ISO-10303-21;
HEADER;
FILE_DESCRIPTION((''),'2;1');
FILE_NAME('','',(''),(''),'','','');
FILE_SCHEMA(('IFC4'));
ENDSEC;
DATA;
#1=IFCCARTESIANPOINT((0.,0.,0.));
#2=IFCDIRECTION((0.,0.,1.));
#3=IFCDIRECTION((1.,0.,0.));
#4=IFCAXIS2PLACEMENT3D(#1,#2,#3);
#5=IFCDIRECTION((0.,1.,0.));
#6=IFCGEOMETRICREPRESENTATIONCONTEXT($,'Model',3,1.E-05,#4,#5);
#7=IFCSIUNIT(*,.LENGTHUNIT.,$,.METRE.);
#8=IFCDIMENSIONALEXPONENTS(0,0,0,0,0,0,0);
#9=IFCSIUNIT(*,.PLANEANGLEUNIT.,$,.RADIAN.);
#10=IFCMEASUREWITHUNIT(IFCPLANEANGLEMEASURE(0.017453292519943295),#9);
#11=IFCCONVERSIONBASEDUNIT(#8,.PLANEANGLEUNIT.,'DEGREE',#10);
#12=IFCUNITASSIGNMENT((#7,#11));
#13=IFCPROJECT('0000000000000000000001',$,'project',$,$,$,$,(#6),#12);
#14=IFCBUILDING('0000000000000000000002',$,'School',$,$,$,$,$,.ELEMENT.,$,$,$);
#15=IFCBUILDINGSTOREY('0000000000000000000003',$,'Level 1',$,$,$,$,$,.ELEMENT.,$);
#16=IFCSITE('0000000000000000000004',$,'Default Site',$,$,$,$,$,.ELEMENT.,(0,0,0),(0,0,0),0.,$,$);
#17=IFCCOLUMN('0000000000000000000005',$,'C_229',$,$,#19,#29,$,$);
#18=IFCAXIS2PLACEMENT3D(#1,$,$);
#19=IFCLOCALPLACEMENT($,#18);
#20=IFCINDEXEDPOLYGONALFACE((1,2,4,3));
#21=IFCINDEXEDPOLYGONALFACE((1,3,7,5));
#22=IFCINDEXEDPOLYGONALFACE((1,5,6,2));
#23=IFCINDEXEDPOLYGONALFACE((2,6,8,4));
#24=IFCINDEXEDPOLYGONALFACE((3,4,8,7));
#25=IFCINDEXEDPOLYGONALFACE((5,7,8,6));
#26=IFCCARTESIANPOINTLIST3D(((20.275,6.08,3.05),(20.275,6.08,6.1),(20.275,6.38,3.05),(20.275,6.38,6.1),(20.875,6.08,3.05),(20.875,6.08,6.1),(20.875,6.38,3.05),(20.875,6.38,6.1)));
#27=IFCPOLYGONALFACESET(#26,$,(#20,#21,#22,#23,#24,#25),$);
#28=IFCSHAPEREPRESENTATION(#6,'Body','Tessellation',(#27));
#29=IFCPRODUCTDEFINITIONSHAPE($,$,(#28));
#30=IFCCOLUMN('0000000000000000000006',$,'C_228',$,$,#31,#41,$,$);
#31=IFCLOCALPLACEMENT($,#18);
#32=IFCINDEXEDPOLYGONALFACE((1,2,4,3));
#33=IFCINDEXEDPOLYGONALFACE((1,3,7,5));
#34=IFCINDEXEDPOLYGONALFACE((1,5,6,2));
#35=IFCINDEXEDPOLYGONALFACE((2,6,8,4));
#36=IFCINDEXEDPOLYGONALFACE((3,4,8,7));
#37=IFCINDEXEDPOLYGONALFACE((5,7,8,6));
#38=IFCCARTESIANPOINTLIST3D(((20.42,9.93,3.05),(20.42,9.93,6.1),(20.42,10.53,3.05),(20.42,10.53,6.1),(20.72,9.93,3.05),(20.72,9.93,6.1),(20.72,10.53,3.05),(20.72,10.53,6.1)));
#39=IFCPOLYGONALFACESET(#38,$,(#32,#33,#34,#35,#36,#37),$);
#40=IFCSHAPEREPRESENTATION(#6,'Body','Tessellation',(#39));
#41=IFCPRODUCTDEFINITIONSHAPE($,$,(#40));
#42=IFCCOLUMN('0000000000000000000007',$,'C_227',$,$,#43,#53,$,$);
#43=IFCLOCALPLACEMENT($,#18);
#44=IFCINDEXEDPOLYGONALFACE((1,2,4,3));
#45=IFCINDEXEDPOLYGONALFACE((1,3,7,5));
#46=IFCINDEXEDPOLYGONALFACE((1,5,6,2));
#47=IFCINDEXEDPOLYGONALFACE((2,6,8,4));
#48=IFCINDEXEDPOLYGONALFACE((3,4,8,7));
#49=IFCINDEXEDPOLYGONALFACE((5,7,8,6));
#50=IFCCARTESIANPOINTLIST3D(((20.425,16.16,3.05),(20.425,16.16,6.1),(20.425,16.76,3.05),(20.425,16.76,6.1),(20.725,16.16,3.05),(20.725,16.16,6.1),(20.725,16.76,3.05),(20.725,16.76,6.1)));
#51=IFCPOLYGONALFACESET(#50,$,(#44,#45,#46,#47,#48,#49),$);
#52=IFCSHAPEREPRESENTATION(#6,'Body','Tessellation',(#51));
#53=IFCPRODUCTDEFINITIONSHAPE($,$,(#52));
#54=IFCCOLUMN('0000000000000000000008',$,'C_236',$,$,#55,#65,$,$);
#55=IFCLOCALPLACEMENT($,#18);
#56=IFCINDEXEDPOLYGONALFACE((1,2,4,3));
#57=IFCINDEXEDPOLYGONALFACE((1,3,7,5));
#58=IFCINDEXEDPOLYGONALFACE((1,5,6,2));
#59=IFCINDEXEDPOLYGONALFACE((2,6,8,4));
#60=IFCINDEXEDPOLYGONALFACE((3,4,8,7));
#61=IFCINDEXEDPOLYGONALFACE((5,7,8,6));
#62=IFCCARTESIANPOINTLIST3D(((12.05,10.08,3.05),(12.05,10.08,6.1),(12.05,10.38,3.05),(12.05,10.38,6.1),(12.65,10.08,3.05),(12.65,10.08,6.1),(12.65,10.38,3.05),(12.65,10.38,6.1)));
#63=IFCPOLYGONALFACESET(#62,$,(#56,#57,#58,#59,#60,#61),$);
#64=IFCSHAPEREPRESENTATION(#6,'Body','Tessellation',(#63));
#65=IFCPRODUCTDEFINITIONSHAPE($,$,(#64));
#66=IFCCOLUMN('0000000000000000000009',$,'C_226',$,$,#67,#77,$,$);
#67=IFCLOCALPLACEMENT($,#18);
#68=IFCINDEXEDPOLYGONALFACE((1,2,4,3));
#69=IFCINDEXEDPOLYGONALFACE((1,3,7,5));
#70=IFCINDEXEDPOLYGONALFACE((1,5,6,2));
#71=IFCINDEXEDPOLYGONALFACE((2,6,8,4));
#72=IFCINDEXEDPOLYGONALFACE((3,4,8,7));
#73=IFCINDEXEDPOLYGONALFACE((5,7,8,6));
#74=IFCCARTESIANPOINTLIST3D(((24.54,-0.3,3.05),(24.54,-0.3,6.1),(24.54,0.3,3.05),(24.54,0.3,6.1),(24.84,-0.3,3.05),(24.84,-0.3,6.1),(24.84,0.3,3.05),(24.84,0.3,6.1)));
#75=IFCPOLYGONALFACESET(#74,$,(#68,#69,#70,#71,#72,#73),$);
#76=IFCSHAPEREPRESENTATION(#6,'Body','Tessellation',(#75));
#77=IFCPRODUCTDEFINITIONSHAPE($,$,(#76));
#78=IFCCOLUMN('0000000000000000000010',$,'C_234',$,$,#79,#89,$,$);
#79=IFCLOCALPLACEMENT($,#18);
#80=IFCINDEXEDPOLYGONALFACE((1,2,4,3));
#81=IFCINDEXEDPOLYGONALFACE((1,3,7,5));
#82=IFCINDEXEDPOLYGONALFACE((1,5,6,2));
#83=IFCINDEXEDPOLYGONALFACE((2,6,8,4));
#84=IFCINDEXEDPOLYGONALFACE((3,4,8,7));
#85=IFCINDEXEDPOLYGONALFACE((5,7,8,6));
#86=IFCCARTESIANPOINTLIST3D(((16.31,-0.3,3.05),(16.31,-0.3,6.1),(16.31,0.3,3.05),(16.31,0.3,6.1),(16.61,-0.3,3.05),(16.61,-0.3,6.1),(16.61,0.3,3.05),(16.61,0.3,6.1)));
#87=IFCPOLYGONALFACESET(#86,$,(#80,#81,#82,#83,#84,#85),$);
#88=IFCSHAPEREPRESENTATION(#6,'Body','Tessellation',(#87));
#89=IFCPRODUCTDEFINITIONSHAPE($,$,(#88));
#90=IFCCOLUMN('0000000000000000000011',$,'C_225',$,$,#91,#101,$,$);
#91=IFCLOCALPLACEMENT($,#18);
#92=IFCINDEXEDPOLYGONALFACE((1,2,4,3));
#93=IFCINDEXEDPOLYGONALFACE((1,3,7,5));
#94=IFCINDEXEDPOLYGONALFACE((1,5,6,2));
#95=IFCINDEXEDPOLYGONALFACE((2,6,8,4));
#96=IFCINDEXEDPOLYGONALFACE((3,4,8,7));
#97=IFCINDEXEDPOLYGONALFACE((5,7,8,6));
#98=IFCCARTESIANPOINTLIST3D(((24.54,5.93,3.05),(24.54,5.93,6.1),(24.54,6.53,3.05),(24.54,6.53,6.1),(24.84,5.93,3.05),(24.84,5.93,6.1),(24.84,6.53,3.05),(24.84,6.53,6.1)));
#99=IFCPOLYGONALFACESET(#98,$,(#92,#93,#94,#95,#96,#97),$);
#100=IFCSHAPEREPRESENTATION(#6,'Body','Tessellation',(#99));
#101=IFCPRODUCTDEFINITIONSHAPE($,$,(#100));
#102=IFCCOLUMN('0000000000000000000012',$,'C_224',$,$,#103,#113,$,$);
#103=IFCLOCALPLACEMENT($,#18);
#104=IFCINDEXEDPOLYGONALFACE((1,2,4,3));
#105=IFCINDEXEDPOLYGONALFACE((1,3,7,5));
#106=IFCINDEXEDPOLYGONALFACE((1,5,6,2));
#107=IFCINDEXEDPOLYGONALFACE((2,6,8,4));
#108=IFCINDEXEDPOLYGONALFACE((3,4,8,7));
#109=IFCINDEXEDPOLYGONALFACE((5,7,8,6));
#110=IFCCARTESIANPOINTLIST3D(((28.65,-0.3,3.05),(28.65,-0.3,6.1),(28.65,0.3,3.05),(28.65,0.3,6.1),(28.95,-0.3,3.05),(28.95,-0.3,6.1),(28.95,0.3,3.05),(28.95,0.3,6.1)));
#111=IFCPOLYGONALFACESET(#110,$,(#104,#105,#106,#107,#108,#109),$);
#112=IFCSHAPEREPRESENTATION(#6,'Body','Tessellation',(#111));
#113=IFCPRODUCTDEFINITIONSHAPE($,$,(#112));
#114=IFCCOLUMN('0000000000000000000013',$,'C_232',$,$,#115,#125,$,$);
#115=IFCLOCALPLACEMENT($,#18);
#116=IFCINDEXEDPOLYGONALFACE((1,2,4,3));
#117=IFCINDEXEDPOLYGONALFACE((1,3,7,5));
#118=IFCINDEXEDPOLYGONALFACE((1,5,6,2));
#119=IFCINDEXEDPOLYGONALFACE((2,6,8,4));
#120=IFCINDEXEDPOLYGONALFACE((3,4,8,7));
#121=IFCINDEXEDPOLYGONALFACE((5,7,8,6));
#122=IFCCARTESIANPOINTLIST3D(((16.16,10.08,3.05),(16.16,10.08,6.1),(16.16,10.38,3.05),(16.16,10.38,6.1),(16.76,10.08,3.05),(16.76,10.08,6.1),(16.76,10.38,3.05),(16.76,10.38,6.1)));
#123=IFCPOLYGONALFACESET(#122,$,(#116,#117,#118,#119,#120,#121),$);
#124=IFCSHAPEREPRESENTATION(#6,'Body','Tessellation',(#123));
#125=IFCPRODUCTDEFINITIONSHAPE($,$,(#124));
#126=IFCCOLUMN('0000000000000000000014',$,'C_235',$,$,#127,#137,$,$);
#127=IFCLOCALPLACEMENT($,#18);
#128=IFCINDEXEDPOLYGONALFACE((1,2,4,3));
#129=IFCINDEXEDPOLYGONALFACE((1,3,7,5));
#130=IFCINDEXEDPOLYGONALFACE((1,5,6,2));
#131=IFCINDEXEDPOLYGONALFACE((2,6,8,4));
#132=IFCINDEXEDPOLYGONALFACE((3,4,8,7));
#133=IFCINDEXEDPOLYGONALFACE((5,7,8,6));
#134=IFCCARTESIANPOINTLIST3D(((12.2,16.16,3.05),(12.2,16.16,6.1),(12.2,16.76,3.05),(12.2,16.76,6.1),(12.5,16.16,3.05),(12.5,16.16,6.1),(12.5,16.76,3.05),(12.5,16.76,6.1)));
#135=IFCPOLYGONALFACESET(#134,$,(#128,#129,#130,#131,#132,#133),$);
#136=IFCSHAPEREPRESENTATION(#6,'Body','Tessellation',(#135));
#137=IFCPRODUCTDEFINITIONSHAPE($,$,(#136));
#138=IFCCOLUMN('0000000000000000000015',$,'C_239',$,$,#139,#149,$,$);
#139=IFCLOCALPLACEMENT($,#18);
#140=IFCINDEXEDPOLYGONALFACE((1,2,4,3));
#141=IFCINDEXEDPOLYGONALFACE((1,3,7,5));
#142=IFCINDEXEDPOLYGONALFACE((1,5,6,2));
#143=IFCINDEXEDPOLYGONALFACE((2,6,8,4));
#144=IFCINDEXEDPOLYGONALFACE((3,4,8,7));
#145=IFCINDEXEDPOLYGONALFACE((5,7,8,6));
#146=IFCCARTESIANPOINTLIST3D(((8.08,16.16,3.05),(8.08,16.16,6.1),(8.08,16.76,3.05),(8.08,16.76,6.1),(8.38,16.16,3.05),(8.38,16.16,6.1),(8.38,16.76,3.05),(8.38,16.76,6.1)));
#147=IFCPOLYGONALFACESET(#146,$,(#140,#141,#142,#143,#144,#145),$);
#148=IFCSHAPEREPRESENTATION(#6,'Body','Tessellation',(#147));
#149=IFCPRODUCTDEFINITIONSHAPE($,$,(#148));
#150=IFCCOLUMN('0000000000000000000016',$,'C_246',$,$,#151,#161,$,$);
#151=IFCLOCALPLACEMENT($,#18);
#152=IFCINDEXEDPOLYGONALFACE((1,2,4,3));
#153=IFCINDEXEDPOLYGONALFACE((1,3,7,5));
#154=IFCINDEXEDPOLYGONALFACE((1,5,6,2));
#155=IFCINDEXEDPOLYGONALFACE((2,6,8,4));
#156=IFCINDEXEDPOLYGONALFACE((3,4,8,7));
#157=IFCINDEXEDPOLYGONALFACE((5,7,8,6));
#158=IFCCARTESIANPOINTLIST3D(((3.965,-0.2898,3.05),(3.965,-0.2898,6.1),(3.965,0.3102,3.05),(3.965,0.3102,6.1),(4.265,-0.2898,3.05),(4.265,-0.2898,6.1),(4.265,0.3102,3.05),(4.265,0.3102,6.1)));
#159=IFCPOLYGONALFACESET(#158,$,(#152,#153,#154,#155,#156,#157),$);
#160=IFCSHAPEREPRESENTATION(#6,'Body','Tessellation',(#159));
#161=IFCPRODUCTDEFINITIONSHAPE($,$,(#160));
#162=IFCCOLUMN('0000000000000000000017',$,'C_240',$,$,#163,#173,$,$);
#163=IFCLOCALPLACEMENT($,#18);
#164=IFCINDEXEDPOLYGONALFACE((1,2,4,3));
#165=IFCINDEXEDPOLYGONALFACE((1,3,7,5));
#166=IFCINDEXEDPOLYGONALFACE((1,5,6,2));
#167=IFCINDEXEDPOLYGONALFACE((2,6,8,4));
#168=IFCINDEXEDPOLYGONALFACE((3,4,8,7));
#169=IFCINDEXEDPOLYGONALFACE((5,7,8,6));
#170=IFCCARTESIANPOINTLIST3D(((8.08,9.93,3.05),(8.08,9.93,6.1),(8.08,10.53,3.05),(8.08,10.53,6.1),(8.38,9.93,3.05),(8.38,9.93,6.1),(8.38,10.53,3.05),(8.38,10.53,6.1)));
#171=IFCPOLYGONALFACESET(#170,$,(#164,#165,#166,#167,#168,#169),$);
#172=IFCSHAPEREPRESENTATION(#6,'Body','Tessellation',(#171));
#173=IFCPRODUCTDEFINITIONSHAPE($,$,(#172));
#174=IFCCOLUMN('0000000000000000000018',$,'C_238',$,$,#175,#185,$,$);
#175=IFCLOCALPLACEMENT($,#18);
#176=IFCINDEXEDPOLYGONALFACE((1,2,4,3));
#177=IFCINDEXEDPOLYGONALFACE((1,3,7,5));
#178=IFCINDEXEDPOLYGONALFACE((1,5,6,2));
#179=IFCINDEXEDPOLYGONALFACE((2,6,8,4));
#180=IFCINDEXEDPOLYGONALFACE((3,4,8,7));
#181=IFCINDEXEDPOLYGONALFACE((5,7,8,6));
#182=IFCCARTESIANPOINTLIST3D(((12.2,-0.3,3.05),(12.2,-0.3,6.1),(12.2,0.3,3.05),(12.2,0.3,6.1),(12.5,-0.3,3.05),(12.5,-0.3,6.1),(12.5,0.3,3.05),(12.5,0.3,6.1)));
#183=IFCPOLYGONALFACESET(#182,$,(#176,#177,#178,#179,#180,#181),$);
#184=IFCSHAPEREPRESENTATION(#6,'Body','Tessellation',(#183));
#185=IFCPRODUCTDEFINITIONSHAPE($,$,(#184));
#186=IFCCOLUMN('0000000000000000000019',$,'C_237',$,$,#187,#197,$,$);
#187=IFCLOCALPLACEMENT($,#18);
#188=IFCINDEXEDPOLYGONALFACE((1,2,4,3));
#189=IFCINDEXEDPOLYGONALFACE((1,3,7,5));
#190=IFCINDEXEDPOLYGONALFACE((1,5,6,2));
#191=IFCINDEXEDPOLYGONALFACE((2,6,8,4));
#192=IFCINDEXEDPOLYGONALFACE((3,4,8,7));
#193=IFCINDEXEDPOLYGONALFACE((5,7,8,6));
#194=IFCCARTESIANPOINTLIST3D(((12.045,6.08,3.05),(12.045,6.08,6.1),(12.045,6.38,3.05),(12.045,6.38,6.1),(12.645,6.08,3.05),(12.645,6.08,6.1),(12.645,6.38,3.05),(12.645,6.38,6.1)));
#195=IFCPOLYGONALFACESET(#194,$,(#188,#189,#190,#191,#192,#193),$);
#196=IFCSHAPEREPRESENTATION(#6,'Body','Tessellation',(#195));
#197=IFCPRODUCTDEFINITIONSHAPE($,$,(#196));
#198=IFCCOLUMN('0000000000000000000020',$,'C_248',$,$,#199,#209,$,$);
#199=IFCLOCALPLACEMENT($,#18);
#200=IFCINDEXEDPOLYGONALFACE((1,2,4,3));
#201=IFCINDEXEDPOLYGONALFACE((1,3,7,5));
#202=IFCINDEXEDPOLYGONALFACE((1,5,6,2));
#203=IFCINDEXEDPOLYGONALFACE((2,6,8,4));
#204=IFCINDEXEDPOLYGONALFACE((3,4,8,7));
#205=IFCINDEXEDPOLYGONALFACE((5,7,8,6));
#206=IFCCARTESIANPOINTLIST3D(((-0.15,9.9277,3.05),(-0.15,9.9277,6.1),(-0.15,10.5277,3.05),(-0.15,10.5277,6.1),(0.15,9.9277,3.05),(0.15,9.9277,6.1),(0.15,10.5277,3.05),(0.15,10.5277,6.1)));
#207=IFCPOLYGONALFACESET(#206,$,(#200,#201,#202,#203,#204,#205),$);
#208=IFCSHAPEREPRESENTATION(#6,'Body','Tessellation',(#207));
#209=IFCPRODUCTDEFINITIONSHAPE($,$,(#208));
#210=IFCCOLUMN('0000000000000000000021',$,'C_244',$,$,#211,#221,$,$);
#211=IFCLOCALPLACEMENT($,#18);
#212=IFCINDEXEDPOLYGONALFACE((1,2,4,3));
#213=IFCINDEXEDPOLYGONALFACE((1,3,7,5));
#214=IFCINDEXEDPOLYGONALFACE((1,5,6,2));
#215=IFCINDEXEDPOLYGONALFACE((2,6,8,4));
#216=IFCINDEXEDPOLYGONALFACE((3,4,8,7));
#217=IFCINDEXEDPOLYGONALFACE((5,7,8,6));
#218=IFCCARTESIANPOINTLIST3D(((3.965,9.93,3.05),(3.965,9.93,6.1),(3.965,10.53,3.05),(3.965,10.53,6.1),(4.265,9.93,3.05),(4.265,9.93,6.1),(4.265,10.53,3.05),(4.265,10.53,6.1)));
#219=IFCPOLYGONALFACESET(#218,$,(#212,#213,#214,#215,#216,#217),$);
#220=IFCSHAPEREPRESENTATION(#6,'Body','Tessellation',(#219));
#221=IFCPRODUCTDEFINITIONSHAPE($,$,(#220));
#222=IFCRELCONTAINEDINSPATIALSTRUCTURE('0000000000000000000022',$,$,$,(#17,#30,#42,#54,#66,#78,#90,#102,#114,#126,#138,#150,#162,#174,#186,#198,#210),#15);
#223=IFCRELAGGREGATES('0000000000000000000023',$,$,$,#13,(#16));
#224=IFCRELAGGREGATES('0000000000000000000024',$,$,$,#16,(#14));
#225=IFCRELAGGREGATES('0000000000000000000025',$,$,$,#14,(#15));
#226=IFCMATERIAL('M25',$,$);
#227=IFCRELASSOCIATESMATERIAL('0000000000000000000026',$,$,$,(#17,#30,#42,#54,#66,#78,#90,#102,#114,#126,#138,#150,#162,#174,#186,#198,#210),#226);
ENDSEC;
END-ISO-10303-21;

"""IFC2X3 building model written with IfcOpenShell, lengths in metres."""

from ifc_helpers import new_model, entity, si_unit, converted_unit, direction, frame, frame_2d, origin_with_axes, place, context, project, spatial, rectangle, extrude, material, element, save


model = new_model("IFC2X3")

# Units and contexts
model_context = context("Model", 3, precision=1e-05, world=origin_with_axes(), true_north=direction((0.0, 1.0, 0.0)))
ifc_project = project(units=[si_unit("LENGTHUNIT", "METRE"), converted_unit("PLANEANGLEUNIT", "DEGREE", entity("IfcPlaneAngleMeasure", 0.017453292519943295), si_unit("PLANEANGLEUNIT", "RADIAN"), dimensions=[0, 0, 0, 0, 0, 0, 0])], contexts=[model_context])

# Site, building, storey
site = spatial("IfcSite", under=ifc_project, Name="Default Site", CompositionType="ELEMENT", RefLatitude=(0, 0, 0), RefLongitude=(0, 0, 0), RefElevation=0.0)
building = spatial("IfcBuilding", under=site, Name="School", CompositionType="ELEMENT")
storey = spatial("IfcBuildingStorey", under=building, Name="Level 1", CompositionType="ELEMENT")

# Columns
ifc_material = material(Name="M25")
placement = place(None, origin_with_axes())
element("IfcColumn", 1, at=placement, inside=storey, material=ifc_material, Name="C_229", context=model_context, shape_type="SweptSolid", body=[
    extrude(rectangle(XDim=0.6, YDim=0.3, at=frame_2d((0.0, 0.0), x_axis=(1.0, 0.0, 0.0))), frame((20.575, 6.23, 3.05), z_axis=(0.0, 0.0, 1.0), x_axis=(1.0, 0.0, 0.0)), (0.0, 0.0, 1.0), 3.05),
])
element("IfcColumn", 2, at=placement, inside=storey, material=ifc_material, Name="C_228", context=model_context, shape_type="SweptSolid", body=[
    extrude(rectangle(XDim=0.3, YDim=0.6, at=frame_2d((0.0, 0.0), x_axis=(1.0, 0.0, 0.0))), frame((20.57, 10.23, 3.05), z_axis=(0.0, 0.0, 1.0), x_axis=(1.0, 0.0, 0.0)), (0.0, 0.0, 1.0), 3.05),
])
element("IfcColumn", 3, at=placement, inside=storey, material=ifc_material, Name="C_227", context=model_context, shape_type="SweptSolid", body=[
    extrude(rectangle(XDim=0.3, YDim=0.6, at=frame_2d((0.0, 0.0), x_axis=(1.0, 0.0, 0.0))), frame((20.575, 16.46, 3.05), z_axis=(0.0, 0.0, 1.0), x_axis=(1.0, 0.0, 0.0)), (0.0, 0.0, 1.0), 3.05),
])
element("IfcColumn", 4, at=placement, inside=storey, material=ifc_material, Name="C_236", context=model_context, shape_type="SweptSolid", body=[
    extrude(rectangle(XDim=0.6, YDim=0.3, at=frame_2d((0.0, 0.0), x_axis=(1.0, 0.0, 0.0))), frame((12.35, 10.23, 3.05), z_axis=(0.0, 0.0, 1.0), x_axis=(1.0, 0.0, 0.0)), (0.0, 0.0, 1.0), 3.05),
])
element("IfcColumn", 5, at=placement, inside=storey, material=ifc_material, Name="C_226", context=model_context, shape_type="SweptSolid", body=[
    extrude(rectangle(XDim=0.3, YDim=0.6, at=frame_2d((0.0, 0.0), x_axis=(1.0, 0.0, 0.0))), frame((24.69, 0.0, 3.05), z_axis=(0.0, 0.0, 1.0), x_axis=(1.0, 0.0, 0.0)), (0.0, 0.0, 1.0), 3.05),
])
element("IfcColumn", 6, at=placement, inside=storey, material=ifc_material, Name="C_234", context=model_context, shape_type="SweptSolid", body=[
    extrude(rectangle(XDim=0.3, YDim=0.6, at=frame_2d((0.0, 0.0), x_axis=(1.0, 0.0, 0.0))), frame((16.46, 0.0, 3.05), z_axis=(0.0, 0.0, 1.0), x_axis=(1.0, 0.0, 0.0)), (0.0, 0.0, 1.0), 3.05),
])
element("IfcColumn", 7, at=placement, inside=storey, material=ifc_material, Name="C_225", context=model_context, shape_type="SweptSolid", body=[
    extrude(rectangle(XDim=0.3, YDim=0.6, at=frame_2d((0.0, 0.0), x_axis=(1.0, 0.0, 0.0))), frame((24.69, 6.23, 3.05), z_axis=(0.0, 0.0, 1.0), x_axis=(1.0, 0.0, 0.0)), (0.0, 0.0, 1.0), 3.05),
])
element("IfcColumn", 8, at=placement, inside=storey, material=ifc_material, Name="C_224", context=model_context, shape_type="SweptSolid", body=[
    extrude(rectangle(XDim=0.3, YDim=0.6, at=frame_2d((0.0, 0.0), x_axis=(1.0, 0.0, 0.0))), frame((28.8, 0.0, 3.05), z_axis=(0.0, 0.0, 1.0), x_axis=(1.0, 0.0, 0.0)), (0.0, 0.0, 1.0), 3.05),
])
element("IfcColumn", 9, at=placement, inside=storey, material=ifc_material, Name="C_232", context=model_context, shape_type="SweptSolid", body=[
    extrude(rectangle(XDim=0.6, YDim=0.3, at=frame_2d((0.0, 0.0), x_axis=(1.0, 0.0, 0.0))), frame((16.46, 10.23, 3.05), z_axis=(0.0, 0.0, 1.0), x_axis=(1.0, 0.0, 0.0)), (0.0, 0.0, 1.0), 3.05),
])
element("IfcColumn", 10, at=placement, inside=storey, material=ifc_material, Name="C_235", context=model_context, shape_type="SweptSolid", body=[
    extrude(rectangle(XDim=0.3, YDim=0.6, at=frame_2d((0.0, 0.0), x_axis=(1.0, 0.0, 0.0))), frame((12.35, 16.46, 3.05), z_axis=(0.0, 0.0, 1.0), x_axis=(1.0, 0.0, 0.0)), (0.0, 0.0, 1.0), 3.05),
])
element("IfcColumn", 11, at=placement, inside=storey, material=ifc_material, Name="C_239", context=model_context, shape_type="SweptSolid", body=[
    extrude(rectangle(XDim=0.3, YDim=0.6, at=frame_2d((0.0, 0.0), x_axis=(1.0, 0.0, 0.0))), frame((8.23, 16.46, 3.05), z_axis=(0.0, 0.0, 1.0), x_axis=(1.0, 0.0, 0.0)), (0.0, 0.0, 1.0), 3.05),
])
element("IfcColumn", 12, at=placement, inside=storey, material=ifc_material, Name="C_246", context=model_context, shape_type="SweptSolid", body=[
    extrude(rectangle(XDim=0.3, YDim=0.6, at=frame_2d((0.0, 0.0), x_axis=(1.0, 0.0, 0.0))), frame((4.115, 0.0102, 3.05), z_axis=(0.0, 0.0, 1.0), x_axis=(1.0, 0.0, 0.0)), (0.0, 0.0, 1.0), 3.05),
])
element("IfcColumn", 13, at=placement, inside=storey, material=ifc_material, Name="C_240", context=model_context, shape_type="SweptSolid", body=[
    extrude(rectangle(XDim=0.3, YDim=0.6, at=frame_2d((0.0, 0.0), x_axis=(1.0, 0.0, 0.0))), frame((8.23, 10.23, 3.05), z_axis=(0.0, 0.0, 1.0), x_axis=(1.0, 0.0, 0.0)), (0.0, 0.0, 1.0), 3.05),
])
element("IfcColumn", 14, at=placement, inside=storey, material=ifc_material, Name="C_238", context=model_context, shape_type="SweptSolid", body=[
    extrude(rectangle(XDim=0.3, YDim=0.6, at=frame_2d((0.0, 0.0), x_axis=(1.0, 0.0, 0.0))), frame((12.35, 0.0, 3.05), z_axis=(0.0, 0.0, 1.0), x_axis=(1.0, 0.0, 0.0)), (0.0, 0.0, 1.0), 3.05),
])
element("IfcColumn", 15, at=placement, inside=storey, material=ifc_material, Name="C_237", context=model_context, shape_type="SweptSolid", body=[
    extrude(rectangle(XDim=0.6, YDim=0.3, at=frame_2d((0.0, 0.0), x_axis=(1.0, 0.0, 0.0))), frame((12.345, 6.23, 3.05), z_axis=(0.0, 0.0, 1.0), x_axis=(1.0, 0.0, 0.0)), (0.0, 0.0, 1.0), 3.05),
])
element("IfcColumn", 16, at=placement, inside=storey, material=ifc_material, Name="C_248", context=model_context, shape_type="SweptSolid", body=[
    extrude(rectangle(XDim=0.3, YDim=0.6, at=frame_2d((0.0, 0.0), x_axis=(1.0, 0.0, 0.0))), frame((0.0, 10.2277, 3.05), z_axis=(0.0, 0.0, 1.0), x_axis=(1.0, 0.0, 0.0)), (0.0, 0.0, 1.0), 3.05),
])
element("IfcColumn", 17, at=placement, inside=storey, material=ifc_material, Name="C_244", context=model_context, shape_type="SweptSolid", body=[
    extrude(rectangle(XDim=0.3, YDim=0.6, at=frame_2d((0.0, 0.0), x_axis=(1.0, 0.0, 0.0))), frame((4.115, 10.23, 3.05), z_axis=(0.0, 0.0, 1.0), x_axis=(1.0, 0.0, 0.0)), (0.0, 0.0, 1.0), 3.05),
])

save(model, "model.ifc")
